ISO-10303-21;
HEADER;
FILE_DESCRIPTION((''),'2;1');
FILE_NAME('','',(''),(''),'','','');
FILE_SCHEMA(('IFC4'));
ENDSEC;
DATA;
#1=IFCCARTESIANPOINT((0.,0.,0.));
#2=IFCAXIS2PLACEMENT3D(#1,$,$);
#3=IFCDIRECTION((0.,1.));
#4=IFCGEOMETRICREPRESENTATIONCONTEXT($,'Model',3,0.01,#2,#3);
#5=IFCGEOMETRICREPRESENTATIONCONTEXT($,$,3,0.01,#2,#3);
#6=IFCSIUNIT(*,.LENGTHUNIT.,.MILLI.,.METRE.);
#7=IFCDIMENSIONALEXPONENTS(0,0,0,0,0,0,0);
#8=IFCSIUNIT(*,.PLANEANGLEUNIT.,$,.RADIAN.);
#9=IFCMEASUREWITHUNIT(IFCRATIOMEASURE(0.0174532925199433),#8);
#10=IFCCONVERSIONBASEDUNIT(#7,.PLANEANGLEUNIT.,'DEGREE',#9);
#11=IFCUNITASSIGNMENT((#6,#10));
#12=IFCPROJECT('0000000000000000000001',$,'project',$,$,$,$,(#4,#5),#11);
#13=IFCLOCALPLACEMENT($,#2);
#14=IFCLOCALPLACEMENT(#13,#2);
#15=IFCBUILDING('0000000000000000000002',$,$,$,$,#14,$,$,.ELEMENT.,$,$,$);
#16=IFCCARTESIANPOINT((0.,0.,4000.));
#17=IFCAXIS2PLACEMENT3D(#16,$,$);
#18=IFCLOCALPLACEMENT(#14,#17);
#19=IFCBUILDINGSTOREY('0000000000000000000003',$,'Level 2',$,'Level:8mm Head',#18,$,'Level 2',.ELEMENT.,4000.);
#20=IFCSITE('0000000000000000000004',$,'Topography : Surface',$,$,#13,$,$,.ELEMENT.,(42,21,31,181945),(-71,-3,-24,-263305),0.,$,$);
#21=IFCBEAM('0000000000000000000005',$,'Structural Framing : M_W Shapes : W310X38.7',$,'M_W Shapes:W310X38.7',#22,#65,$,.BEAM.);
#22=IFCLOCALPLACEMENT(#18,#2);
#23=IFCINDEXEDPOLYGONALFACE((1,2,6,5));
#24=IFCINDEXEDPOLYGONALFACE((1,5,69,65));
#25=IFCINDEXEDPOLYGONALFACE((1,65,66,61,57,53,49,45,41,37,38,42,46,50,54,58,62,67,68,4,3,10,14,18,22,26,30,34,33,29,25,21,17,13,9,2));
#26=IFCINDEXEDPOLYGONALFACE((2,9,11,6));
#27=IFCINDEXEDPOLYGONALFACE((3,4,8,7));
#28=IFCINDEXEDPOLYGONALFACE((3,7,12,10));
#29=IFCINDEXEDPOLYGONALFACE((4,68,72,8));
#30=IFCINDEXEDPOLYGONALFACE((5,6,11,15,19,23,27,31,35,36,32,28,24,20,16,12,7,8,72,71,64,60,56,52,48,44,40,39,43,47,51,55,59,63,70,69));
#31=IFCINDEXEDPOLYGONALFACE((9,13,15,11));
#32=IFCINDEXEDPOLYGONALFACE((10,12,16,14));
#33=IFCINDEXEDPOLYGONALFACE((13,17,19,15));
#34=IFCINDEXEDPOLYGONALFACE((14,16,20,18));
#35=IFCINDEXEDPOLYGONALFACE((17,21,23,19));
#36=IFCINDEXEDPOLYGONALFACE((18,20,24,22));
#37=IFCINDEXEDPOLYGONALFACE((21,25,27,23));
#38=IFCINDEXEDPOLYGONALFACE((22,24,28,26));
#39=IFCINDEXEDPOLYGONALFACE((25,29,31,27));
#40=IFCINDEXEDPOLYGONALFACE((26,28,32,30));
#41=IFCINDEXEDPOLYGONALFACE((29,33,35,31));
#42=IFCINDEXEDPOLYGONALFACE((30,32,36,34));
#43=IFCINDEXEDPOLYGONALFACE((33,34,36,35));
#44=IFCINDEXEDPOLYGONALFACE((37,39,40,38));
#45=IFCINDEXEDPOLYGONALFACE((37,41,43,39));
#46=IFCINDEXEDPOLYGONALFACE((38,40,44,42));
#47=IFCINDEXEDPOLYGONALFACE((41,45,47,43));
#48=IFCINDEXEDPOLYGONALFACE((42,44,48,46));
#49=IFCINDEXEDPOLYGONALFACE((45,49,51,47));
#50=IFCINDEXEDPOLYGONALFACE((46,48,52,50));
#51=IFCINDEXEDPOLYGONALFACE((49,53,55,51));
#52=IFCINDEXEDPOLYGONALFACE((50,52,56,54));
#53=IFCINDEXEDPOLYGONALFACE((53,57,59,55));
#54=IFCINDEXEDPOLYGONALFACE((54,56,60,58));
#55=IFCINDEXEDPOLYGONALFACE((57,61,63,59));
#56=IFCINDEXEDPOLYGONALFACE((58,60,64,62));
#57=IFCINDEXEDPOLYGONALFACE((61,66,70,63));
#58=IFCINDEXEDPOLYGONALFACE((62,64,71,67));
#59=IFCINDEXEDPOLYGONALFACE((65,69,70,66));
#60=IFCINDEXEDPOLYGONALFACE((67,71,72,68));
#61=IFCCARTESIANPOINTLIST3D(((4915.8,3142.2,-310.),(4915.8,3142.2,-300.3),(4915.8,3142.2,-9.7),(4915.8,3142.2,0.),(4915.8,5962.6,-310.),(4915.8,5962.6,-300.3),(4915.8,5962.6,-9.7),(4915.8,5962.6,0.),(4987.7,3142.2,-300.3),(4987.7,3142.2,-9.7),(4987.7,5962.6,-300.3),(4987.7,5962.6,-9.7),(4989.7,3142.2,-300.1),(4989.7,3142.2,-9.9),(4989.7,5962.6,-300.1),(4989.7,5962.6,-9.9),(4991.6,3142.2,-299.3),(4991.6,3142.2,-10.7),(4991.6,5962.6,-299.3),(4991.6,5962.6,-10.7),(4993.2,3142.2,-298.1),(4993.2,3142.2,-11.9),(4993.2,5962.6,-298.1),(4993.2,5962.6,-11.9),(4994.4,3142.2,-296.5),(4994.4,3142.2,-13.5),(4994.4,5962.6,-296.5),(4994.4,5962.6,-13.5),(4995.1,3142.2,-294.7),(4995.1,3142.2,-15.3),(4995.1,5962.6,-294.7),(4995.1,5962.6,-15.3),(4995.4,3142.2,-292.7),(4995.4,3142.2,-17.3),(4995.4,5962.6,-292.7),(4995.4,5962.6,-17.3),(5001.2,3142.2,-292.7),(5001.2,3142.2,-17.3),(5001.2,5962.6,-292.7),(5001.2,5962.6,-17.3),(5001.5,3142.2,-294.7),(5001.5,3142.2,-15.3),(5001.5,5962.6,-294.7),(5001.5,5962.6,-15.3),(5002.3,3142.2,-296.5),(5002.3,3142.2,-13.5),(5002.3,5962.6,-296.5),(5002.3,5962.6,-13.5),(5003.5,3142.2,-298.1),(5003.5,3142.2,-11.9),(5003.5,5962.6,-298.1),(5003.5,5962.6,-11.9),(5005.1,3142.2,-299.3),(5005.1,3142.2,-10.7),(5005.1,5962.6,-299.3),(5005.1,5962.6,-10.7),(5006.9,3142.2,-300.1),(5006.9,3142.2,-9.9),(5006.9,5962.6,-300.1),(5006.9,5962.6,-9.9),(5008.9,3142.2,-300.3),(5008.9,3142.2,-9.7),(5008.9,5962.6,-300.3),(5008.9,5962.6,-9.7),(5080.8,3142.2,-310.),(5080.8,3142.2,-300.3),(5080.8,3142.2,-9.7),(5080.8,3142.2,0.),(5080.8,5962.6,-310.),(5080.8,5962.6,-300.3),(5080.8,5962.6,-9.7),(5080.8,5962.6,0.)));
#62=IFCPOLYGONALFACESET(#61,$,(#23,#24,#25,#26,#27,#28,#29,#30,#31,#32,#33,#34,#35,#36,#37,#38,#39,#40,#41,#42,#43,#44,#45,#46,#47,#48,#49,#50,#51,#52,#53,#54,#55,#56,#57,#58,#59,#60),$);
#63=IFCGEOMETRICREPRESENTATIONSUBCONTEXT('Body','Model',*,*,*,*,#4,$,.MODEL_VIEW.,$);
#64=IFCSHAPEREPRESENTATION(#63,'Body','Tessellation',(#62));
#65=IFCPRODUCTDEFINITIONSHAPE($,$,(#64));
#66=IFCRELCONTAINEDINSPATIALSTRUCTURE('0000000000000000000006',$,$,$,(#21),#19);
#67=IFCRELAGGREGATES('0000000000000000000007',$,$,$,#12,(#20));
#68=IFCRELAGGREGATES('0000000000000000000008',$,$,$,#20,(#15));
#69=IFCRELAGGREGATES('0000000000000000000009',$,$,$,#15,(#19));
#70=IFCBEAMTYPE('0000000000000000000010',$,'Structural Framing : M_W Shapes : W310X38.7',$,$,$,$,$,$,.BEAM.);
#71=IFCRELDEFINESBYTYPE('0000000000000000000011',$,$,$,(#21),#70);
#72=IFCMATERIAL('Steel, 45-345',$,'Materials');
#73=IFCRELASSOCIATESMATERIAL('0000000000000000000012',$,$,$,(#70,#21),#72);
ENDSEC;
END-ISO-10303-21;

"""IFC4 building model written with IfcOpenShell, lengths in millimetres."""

from ifc_helpers import new_model, entity, si_unit, converted_unit, direction, frame, frame_2d, origin, place, context, subcontext, project, spatial, i_section, extrude, source, transform, mapped, material, material_profile, profile_set, profile_usage, type_object, type_shapes, element, save


model = new_model("IFC4")

# Units and contexts
model_context = context("Model", 3, precision=0.01, world=origin(), true_north=direction((0.0, 1.0)))
context_of_model = context(None, 3, precision=0.01, world=origin(), true_north=direction((0.0, 1.0)))
body_context = subcontext(model_context, "Body", "Model", "MODEL_VIEW")
ifc_project = project(units=[si_unit("LENGTHUNIT", "METRE", prefix="MILLI"), converted_unit("PLANEANGLEUNIT", "DEGREE", entity("IfcRatioMeasure", 0.0174532925199433), si_unit("PLANEANGLEUNIT", "RADIAN"), dimensions=[0, 0, 0, 0, 0, 0, 0])], contexts=[model_context, context_of_model])

# Site, building, storey
site_placement = place(None, origin())
site = spatial("IfcSite", under=ifc_project, at=site_placement, Name="Topography : Surface", CompositionType="ELEMENT", RefLatitude=(42, 21, 31, 181945), RefLongitude=(-71, -3, -24, -263305), RefElevation=0.0)
building_placement = place(site_placement, origin())
building = spatial("IfcBuilding", under=site, at=building_placement, CompositionType="ELEMENT")
storey_placement = place(building_placement, frame((0.0, 0.0, 4000.0)))
storey = spatial("IfcBuildingStorey", under=building, at=storey_placement, Name="Level 2", ObjectType="Level:8mm Head", LongName="Level 2", CompositionType="ELEMENT", Elevation=4000.0)

# Beam
ifc_material = material(Name="Steel, 45-345", Category="Materials")
ifc_material_profile = material_profile(ifc_material, i_section(OverallWidth=165.0, OverallDepth=310.0, WebThickness=5.8, FlangeThickness=9.7, FilletRadius=7.7, at=frame_2d((0.0, 0.0), x_axis=(0.0, 1.0))), Name="W310X38.7")
ifc_profile_set = profile_set([ifc_material_profile], Name="W310X38.7")
ifc_profile_usage = profile_usage(ifc_profile_set, cardinal=8)
beam_type = type_object("IfcBeamType", Name="Structural Framing : M_W Shapes : W310X38.7", PredefinedType="BEAM", material=ifc_profile_set)
shared_shape = source(origin(), body_context, "Body", "SweptSolid", [
    extrude(i_section(OverallWidth=165.0, OverallDepth=310.0, WebThickness=5.8, FlangeThickness=9.7, FilletRadius=7.7, at=frame_2d((0.0, 0.0), x_axis=(0.0, 1.0))), frame((-1410.2, 0.0, 0.0), z_axis=(1.0, 0.0, 0.0), x_axis=(0.0, 0.0, -1.0)), (0.0, 0.0, 1.0), 2820.4),
])
type_shapes(beam_type, [shared_shape])
beam_placement = place(storey_placement, frame((4998.3, 4552.4, -155.0), z_axis=(0.0, 0.0, 1.0), x_axis=(0.0, -1.0, 0.0)))
element("IfcBeam", 1, at=beam_placement, inside=storey, type_object=beam_type, material=ifc_profile_usage, Name="Structural Framing : M_W Shapes : W310X38.7", ObjectType="M_W Shapes:W310X38.7", PredefinedType="BEAM", context=body_context, shape_type="MappedRepresentation", body=[
    mapped(shared_shape, transform((0.0, 0.0, 0.0), scale=1.0)),
])

save(model, "model.ifc")
